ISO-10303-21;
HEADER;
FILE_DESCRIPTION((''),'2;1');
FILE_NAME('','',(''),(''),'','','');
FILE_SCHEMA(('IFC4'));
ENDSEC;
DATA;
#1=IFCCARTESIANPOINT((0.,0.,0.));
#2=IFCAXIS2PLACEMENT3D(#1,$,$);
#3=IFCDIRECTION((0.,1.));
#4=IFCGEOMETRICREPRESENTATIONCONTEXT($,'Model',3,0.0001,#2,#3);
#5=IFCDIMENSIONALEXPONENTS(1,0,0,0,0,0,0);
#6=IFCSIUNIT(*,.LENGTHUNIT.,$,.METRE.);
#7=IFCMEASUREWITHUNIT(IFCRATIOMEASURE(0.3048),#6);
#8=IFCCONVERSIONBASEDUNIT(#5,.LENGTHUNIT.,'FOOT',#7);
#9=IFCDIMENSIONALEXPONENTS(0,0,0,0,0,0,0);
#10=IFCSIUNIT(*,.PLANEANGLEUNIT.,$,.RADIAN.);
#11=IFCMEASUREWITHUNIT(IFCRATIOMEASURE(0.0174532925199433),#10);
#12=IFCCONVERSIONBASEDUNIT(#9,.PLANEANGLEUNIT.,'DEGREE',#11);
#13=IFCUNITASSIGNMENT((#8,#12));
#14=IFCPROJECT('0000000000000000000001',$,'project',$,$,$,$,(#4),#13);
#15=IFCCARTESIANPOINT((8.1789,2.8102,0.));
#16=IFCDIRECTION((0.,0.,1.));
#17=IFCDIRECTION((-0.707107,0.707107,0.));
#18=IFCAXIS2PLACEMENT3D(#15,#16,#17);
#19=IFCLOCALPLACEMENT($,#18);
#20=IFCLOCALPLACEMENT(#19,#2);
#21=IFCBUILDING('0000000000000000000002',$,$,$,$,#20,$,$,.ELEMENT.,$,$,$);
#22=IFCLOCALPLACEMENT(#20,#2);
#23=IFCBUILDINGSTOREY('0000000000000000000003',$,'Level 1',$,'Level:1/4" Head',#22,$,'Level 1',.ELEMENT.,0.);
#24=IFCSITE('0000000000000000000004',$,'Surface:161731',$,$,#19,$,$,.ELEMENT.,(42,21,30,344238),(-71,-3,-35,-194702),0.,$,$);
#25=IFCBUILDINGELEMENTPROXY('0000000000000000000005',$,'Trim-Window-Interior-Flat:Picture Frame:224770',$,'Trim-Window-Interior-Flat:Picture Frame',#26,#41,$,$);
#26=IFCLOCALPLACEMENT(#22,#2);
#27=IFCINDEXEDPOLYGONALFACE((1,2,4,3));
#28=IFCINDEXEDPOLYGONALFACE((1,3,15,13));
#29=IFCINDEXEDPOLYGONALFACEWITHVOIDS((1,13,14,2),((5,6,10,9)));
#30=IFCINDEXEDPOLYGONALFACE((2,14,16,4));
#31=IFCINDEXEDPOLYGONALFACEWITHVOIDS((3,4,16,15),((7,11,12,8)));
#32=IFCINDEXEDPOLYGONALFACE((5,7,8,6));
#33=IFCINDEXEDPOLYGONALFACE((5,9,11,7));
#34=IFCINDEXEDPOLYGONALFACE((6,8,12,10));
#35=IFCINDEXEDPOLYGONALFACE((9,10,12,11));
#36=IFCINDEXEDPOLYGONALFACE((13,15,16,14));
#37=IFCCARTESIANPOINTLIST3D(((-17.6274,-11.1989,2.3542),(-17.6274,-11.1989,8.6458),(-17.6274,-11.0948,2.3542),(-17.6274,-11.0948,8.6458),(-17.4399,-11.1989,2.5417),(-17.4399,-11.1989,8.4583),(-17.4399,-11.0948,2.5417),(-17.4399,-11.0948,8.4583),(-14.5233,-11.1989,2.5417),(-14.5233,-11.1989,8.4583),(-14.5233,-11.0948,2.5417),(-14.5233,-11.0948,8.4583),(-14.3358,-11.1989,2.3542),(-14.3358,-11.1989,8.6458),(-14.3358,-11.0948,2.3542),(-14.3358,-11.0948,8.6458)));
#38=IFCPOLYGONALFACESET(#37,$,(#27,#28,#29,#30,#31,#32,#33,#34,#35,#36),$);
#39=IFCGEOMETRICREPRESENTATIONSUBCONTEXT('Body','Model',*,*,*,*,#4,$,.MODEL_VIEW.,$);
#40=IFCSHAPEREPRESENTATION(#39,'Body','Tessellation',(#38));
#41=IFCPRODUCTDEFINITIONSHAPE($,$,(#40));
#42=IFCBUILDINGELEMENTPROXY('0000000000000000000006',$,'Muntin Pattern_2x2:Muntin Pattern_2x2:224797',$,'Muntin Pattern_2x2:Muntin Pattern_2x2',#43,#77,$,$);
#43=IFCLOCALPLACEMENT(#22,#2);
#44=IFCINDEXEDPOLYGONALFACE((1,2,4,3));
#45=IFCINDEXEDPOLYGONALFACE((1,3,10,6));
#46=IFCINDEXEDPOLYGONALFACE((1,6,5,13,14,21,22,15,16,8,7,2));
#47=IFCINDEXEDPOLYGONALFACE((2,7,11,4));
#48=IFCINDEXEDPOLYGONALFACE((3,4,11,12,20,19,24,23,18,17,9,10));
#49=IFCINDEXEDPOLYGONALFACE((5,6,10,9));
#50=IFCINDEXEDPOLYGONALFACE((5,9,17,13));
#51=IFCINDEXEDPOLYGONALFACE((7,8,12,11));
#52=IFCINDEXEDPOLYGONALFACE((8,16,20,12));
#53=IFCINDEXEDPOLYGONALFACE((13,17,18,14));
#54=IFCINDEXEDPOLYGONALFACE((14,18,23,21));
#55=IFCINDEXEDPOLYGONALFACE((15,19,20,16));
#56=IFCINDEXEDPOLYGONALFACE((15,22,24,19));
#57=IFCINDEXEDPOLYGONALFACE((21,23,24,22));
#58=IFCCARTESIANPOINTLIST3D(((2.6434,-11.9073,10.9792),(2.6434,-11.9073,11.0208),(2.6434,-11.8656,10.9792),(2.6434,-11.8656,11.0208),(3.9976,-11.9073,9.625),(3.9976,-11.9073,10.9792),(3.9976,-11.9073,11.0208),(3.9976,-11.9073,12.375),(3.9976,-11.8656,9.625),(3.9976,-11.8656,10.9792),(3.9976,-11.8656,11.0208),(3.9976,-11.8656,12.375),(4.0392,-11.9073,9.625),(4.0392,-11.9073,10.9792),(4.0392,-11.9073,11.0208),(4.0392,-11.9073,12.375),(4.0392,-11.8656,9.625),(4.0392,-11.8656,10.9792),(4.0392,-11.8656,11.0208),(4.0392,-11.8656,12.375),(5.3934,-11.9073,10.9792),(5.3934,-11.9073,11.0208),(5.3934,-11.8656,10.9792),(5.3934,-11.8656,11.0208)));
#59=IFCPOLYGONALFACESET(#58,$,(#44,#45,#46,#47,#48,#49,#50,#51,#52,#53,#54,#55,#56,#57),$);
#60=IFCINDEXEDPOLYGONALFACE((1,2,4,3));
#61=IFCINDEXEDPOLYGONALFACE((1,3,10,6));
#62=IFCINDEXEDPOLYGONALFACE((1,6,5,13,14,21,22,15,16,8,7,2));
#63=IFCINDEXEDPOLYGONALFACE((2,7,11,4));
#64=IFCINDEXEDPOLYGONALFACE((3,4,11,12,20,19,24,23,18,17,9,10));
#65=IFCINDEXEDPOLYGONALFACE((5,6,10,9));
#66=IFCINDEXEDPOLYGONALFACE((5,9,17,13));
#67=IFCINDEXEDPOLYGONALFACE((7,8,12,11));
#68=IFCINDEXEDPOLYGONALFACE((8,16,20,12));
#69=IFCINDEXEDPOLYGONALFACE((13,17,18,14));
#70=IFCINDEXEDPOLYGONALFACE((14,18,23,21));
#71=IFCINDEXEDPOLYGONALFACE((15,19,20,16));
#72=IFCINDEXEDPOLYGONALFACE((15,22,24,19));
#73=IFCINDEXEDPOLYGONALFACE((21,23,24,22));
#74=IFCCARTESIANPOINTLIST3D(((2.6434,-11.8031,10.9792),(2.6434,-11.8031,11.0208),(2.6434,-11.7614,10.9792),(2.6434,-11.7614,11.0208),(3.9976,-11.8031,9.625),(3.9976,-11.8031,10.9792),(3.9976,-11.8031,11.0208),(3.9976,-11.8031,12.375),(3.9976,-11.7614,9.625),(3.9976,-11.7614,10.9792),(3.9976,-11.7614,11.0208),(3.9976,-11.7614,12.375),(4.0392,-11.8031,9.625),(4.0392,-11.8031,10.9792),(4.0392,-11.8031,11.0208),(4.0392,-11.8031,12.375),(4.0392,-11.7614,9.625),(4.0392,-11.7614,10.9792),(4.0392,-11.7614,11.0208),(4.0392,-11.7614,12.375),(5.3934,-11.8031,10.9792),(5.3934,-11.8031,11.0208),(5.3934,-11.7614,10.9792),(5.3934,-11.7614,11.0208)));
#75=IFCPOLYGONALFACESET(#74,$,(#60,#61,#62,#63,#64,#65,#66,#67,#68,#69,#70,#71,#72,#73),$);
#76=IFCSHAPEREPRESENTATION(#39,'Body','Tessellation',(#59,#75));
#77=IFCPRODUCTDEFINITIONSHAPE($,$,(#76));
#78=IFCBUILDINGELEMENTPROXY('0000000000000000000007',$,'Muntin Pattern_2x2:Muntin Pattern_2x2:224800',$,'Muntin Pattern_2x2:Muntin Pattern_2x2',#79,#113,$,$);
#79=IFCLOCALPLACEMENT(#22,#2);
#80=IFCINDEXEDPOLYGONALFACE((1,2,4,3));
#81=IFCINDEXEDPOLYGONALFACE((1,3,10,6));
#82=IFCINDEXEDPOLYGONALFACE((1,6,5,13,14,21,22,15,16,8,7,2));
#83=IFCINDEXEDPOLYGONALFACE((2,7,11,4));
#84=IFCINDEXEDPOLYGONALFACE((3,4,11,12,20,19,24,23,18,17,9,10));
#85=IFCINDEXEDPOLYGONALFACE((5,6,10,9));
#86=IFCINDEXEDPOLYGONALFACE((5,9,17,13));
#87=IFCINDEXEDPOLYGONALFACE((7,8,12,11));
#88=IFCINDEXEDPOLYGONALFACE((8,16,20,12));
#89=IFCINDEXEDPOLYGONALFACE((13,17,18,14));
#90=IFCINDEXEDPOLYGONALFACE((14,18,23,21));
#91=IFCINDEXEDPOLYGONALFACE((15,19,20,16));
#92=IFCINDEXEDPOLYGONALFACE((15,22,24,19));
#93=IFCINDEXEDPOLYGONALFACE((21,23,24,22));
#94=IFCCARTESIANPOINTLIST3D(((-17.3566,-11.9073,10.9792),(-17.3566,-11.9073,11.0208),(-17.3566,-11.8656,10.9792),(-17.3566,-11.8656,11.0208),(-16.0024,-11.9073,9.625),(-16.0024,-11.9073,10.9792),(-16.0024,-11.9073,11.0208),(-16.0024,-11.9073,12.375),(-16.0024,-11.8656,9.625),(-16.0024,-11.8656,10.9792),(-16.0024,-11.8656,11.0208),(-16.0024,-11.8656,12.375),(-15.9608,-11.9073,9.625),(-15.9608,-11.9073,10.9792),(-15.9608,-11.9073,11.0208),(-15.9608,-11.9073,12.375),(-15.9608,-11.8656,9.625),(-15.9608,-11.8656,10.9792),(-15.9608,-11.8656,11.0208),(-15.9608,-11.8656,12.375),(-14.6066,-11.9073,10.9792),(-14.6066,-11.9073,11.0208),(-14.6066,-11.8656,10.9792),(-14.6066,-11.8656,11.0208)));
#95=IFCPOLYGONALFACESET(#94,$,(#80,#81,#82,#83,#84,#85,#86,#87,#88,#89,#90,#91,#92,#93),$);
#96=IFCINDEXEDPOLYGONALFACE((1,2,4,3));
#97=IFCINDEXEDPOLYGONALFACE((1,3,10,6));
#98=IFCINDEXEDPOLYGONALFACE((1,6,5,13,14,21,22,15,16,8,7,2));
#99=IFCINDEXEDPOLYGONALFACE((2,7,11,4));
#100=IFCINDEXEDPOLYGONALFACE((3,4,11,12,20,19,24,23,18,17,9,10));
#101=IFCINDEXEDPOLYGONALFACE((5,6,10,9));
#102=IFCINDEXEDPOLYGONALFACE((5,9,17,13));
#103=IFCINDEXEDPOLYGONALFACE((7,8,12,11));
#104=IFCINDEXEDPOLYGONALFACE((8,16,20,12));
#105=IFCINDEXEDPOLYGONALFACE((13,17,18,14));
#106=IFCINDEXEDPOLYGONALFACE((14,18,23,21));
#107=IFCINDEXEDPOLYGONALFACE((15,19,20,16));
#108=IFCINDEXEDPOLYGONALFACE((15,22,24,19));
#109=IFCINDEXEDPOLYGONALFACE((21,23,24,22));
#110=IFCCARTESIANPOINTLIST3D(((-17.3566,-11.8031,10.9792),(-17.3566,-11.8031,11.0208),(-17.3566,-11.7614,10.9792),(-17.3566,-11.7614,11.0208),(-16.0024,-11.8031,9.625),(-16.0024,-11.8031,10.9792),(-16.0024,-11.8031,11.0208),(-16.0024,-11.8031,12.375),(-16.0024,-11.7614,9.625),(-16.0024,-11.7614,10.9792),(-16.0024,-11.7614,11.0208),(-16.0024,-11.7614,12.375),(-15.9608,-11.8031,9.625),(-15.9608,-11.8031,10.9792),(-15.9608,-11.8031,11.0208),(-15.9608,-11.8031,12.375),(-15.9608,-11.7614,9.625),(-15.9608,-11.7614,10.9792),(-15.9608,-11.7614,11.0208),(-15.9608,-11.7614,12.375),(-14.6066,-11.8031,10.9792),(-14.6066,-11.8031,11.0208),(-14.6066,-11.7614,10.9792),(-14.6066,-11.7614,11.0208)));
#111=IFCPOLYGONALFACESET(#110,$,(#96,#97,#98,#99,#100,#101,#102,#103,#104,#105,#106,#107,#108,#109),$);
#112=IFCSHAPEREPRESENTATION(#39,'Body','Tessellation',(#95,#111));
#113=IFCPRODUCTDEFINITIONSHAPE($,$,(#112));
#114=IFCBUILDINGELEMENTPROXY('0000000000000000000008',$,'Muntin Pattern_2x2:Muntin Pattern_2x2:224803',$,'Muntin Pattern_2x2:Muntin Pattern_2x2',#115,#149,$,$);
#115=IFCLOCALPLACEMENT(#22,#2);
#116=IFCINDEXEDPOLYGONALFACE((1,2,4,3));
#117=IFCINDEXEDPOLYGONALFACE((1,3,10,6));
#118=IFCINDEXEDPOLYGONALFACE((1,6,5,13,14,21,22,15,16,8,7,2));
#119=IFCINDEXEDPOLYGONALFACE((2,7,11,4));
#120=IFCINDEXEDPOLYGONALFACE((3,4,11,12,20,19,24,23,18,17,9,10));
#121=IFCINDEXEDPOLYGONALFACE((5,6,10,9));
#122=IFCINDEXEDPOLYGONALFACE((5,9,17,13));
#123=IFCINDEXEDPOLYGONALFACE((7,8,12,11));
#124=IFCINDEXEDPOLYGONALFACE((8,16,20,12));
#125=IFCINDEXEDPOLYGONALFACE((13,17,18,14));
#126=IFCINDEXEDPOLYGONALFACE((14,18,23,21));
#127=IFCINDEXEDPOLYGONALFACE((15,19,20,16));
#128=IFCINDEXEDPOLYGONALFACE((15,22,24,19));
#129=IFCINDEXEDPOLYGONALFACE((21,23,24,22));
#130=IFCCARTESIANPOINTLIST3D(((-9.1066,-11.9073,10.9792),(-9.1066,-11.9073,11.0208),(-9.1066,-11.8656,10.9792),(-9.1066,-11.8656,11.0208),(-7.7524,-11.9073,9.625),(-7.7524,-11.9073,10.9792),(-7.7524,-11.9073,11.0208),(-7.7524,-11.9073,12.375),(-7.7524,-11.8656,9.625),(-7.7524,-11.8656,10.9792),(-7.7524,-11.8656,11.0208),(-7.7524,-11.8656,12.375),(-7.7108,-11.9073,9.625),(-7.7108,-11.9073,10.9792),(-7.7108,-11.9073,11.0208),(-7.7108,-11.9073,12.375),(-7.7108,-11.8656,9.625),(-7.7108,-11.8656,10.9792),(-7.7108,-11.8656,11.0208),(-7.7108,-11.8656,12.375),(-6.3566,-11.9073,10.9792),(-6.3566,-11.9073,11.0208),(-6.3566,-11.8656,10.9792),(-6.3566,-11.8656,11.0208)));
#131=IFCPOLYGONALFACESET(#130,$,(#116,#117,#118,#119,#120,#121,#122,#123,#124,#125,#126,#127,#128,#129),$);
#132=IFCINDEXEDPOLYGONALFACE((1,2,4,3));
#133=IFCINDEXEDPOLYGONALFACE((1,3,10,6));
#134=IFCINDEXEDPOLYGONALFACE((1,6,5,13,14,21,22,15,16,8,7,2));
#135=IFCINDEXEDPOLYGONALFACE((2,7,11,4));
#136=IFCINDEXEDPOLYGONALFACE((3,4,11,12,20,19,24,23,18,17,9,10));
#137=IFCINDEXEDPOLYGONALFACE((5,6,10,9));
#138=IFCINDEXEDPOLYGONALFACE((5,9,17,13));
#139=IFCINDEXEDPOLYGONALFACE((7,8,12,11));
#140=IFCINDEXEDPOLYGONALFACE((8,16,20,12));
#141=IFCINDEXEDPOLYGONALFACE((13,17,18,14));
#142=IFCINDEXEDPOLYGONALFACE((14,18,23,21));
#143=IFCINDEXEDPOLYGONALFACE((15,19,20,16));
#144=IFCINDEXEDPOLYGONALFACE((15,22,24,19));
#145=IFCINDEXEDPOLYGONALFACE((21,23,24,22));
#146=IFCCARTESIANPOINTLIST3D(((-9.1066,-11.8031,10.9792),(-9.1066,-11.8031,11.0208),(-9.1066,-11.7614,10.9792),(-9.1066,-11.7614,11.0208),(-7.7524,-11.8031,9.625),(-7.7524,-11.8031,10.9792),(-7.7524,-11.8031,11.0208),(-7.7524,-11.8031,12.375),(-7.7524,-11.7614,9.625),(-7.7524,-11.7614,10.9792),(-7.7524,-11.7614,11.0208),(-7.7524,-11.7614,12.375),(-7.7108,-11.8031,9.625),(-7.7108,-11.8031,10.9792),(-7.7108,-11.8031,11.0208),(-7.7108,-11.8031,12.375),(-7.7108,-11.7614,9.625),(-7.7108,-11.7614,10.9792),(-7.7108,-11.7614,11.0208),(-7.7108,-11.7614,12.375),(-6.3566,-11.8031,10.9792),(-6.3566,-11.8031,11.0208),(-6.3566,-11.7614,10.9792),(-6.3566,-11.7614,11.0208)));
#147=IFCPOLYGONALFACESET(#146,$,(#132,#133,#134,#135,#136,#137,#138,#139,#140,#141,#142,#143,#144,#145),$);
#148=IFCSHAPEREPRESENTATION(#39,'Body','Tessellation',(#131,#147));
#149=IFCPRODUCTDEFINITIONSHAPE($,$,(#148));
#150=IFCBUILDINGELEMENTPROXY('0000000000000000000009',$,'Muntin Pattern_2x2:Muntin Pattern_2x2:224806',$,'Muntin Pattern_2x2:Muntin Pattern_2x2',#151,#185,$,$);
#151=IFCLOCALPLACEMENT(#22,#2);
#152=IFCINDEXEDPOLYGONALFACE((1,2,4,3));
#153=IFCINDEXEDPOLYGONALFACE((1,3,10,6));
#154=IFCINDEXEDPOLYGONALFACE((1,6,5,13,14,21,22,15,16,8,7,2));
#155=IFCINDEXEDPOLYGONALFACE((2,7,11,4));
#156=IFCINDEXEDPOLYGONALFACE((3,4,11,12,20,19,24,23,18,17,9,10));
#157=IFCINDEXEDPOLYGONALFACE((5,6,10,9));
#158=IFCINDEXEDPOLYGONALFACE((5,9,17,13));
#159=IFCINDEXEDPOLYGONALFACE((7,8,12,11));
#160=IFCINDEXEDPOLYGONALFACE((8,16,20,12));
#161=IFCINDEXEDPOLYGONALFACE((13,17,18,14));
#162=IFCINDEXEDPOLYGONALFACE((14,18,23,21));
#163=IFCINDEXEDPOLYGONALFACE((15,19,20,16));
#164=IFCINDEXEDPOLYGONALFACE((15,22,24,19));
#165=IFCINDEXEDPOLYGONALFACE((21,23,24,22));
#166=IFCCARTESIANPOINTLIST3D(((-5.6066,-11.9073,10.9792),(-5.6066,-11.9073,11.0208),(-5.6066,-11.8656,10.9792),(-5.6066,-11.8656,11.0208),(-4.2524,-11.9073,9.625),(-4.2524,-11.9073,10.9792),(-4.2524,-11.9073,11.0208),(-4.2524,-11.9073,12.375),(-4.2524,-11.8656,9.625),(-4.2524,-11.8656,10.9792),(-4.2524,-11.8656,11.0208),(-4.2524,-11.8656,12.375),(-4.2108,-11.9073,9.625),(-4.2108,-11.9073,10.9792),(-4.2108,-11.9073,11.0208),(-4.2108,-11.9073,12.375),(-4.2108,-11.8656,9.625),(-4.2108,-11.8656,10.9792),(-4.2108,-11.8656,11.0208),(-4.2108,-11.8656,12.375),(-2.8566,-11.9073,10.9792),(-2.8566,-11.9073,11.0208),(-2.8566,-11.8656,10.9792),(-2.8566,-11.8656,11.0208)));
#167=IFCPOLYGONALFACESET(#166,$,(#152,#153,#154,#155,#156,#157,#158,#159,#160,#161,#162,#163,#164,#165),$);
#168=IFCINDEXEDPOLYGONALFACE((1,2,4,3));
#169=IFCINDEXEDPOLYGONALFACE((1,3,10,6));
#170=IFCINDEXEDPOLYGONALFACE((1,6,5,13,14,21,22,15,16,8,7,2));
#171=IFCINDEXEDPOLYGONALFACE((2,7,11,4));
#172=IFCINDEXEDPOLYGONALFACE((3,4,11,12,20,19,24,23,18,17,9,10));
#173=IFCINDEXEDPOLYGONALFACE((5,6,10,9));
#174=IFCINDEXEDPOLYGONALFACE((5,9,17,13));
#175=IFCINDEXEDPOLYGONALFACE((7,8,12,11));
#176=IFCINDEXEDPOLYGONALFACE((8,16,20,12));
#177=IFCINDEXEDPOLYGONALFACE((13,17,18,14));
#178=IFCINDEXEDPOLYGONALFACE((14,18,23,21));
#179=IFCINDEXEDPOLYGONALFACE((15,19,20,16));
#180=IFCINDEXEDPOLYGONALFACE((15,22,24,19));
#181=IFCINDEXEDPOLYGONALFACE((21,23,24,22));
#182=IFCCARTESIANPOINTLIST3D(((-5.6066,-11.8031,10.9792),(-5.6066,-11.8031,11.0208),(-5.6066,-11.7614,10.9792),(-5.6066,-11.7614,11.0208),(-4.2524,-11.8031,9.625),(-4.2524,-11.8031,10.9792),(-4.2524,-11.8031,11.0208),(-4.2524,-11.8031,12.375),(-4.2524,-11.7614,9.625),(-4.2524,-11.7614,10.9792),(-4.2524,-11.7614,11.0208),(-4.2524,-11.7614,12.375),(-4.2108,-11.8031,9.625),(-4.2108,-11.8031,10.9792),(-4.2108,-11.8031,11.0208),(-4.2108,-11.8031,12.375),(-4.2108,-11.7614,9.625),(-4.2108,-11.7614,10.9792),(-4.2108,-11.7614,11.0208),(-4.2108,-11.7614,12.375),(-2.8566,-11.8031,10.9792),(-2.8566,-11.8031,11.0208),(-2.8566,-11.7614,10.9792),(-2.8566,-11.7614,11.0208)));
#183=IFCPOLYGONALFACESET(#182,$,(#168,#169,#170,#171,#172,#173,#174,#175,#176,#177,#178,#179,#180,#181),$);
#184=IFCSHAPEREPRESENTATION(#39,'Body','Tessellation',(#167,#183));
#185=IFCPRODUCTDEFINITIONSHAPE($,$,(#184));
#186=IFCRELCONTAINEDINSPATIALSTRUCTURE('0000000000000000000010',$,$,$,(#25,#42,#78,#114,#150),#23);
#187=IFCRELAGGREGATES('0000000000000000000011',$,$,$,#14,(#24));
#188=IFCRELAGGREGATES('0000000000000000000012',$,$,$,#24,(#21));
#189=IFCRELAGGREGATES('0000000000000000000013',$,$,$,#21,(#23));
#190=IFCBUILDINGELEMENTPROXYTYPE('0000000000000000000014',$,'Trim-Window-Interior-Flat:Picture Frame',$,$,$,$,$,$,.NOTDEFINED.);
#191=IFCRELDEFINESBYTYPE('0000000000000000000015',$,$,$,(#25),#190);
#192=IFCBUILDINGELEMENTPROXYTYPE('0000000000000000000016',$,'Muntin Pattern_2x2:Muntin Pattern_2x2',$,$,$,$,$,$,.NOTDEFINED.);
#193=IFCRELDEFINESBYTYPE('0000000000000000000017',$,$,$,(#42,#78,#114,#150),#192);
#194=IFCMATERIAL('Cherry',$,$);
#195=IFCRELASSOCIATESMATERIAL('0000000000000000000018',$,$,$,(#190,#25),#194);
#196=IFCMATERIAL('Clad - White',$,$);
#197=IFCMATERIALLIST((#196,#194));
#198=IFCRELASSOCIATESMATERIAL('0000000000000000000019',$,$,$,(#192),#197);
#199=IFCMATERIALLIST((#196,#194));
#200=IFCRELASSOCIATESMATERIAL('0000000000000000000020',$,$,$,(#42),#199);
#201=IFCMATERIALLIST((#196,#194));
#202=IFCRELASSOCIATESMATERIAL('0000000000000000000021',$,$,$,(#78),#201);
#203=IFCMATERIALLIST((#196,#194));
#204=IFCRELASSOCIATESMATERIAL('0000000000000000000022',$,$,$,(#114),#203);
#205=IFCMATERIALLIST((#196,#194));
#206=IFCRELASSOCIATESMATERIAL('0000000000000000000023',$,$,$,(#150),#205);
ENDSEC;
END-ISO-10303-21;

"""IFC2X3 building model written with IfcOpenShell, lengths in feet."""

from ifc_helpers import new_model, entity, si_unit, converted_unit, direction, frame, origin, place, context, subcontext, project, spatial, polyline, outline, extrude, source, transform, mapped, material, material_list, type_object, type_shapes, element, save


model = new_model("IFC2X3")

# Units and contexts
model_context = context("Model", 3, precision=0.0001, world=origin(), true_north=direction((0.0, 1.0)))
body_context = subcontext(model_context, "Body", "Model", "MODEL_VIEW")
ifc_project = project(units=[converted_unit("LENGTHUNIT", "FOOT", entity("IfcRatioMeasure", 0.3048), si_unit("LENGTHUNIT", "METRE"), dimensions=[1, 0, 0, 0, 0, 0, 0]), converted_unit("PLANEANGLEUNIT", "DEGREE", entity("IfcRatioMeasure", 0.0174532925199433), si_unit("PLANEANGLEUNIT", "RADIAN"), dimensions=[0, 0, 0, 0, 0, 0, 0])], contexts=[model_context])

# Site, building, storey
site_placement = place(None, frame((8.1789, 2.8102, 0.0), z_axis=(0.0, 0.0, 1.0), x_axis=(-0.707107, 0.707107, 0.0)))
site = spatial("IfcSite", under=ifc_project, at=site_placement, Name="Surface:161731", CompositionType="ELEMENT", RefLatitude=(42, 21, 30, 344238), RefLongitude=(-71, -3, -35, -194702), RefElevation=0.0)
building_placement = place(site_placement, origin())
building = spatial("IfcBuilding", under=site, at=building_placement, CompositionType="ELEMENT")
storey_placement = place(building_placement, origin())
storey = spatial("IfcBuildingStorey", under=building, at=storey_placement, Name="Level 1", ObjectType="Level:1/4\" Head", LongName="Level 1", CompositionType="ELEMENT", Elevation=0.0)

# Building element proxies
ifc_material_1 = material(Name="Clad - White")
ifc_material_2 = material(Name="Cherry")
building_element_proxy_type_1 = type_object("IfcBuildingElementProxyType", Name="Trim-Window-Interior-Flat:Picture Frame", PredefinedType="NOTDEFINED", material=ifc_material_2)
shared_shape_1 = source(origin(), body_context, "Body", "SweptSolid", [
    extrude(outline(polyline([(-1.6458, -3.1458), (1.6458, -3.1458), (1.6458, 3.1458), (-1.6458, 3.1458), (-1.6458, -3.1458)]), holes=[polyline([(-1.4583, -2.9583), (-1.4583, 2.9583), (1.4583, 2.9583), (1.4583, -2.9583), (-1.4583, -2.9583)])]), frame((0.0, -3.0, 0.0), z_axis=(0.0, 0.0, 1.0), x_axis=(-1.0, 0.0, 0.0)), (0.0, 0.0, 1.0), 0.1042),
])
type_shapes(building_element_proxy_type_1, [shared_shape_1])
for number, where, z_axis, x_axis, name in (
    (1, (-15.9816, -11.1989, 8.5), (0.0, 1.0, 0.0), (-1.0, 0.0, 0.0), "Trim-Window-Interior-Flat:Picture Frame:224770"),
):
    element("IfcBuildingElementProxy", number, at=place(storey_placement, frame(where, z_axis=z_axis, x_axis=x_axis)), inside=storey, type_object=building_element_proxy_type_1, material=ifc_material_2, Name=name, ObjectType="Trim-Window-Interior-Flat:Picture Frame", context=body_context, shape_type="MappedRepresentation", body=[
        mapped(shared_shape_1, transform((0.0, 0.0, 0.0), scale=1.0)),
    ])
ifc_material_list_1 = material_list([ifc_material_1, ifc_material_2])
ifc_material_list_2 = material_list([ifc_material_1, ifc_material_2])
building_element_proxy_type_2 = type_object("IfcBuildingElementProxyType", Name="Muntin Pattern_2x2:Muntin Pattern_2x2", PredefinedType="NOTDEFINED", material=ifc_material_list_2)
shared_shape_2 = source(origin(), body_context, "Body", "SweptSolid", [
    extrude(outline(polyline([(0.0208, -0.0208), (1.375, -0.0208), (1.375, 0.0208), (0.0208, 0.0208), (0.0208, 1.375), (-0.0208, 1.375), (-0.0208, 0.0208), (-1.375, 0.0208), (-1.375, -0.0208), (-0.0208, -0.0208), (-0.0208, -1.375), (0.0208, -1.375), (0.0208, -0.0208)])), frame((0.0, -0.0729, 1.375), z_axis=(0.0, 1.0, 0.0), x_axis=(0.0, 0.0, 1.0)), (0.0, 0.0, 1.0), 0.0417),
    extrude(outline(polyline([(0.0208, -0.0208), (1.375, -0.0208), (1.375, 0.0208), (0.0208, 0.0208), (0.0208, 1.375), (-0.0208, 1.375), (-0.0208, 0.0208), (-1.375, 0.0208), (-1.375, -0.0208), (-0.0208, -0.0208), (-0.0208, -1.375), (0.0208, -1.375), (0.0208, -0.0208)])), frame((0.0, 0.0313, 1.375), z_axis=(0.0, 1.0, 0.0), x_axis=(0.0, 0.0, 1.0)), (0.0, 0.0, 1.0), 0.0417),
])
type_shapes(building_element_proxy_type_2, [shared_shape_2])
proxy_1_placement = place(storey_placement, frame((4.0184, -11.8344, 9.625)))
element("IfcBuildingElementProxy", 2, at=proxy_1_placement, inside=storey, type_object=building_element_proxy_type_2, material=ifc_material_list_1, Name="Muntin Pattern_2x2:Muntin Pattern_2x2:224797", ObjectType="Muntin Pattern_2x2:Muntin Pattern_2x2", context=body_context, shape_type="MappedRepresentation", body=[
    mapped(shared_shape_2, transform((0.0, 0.0, 0.0), scale=1.0)),
])
ifc_material_list_3 = material_list([ifc_material_1, ifc_material_2])
proxy_2_placement = place(storey_placement, frame((-15.9816, -11.8344, 9.625)))
element("IfcBuildingElementProxy", 3, at=proxy_2_placement, inside=storey, type_object=building_element_proxy_type_2, material=ifc_material_list_3, Name="Muntin Pattern_2x2:Muntin Pattern_2x2:224800", ObjectType="Muntin Pattern_2x2:Muntin Pattern_2x2", context=body_context, shape_type="MappedRepresentation", body=[
    mapped(shared_shape_2, transform((0.0, 0.0, 0.0), scale=1.0)),
])
ifc_material_list_4 = material_list([ifc_material_1, ifc_material_2])
proxy_3_placement = place(storey_placement, frame((-7.7316, -11.8344, 9.625)))
element("IfcBuildingElementProxy", 4, at=proxy_3_placement, inside=storey, type_object=building_element_proxy_type_2, material=ifc_material_list_4, Name="Muntin Pattern_2x2:Muntin Pattern_2x2:224803", ObjectType="Muntin Pattern_2x2:Muntin Pattern_2x2", context=body_context, shape_type="MappedRepresentation", body=[
    mapped(shared_shape_2, transform((0.0, 0.0, 0.0), scale=1.0)),
])
ifc_material_list_5 = material_list([ifc_material_1, ifc_material_2])
proxy_4_placement = place(storey_placement, frame((-4.2316, -11.8344, 9.625)))
element("IfcBuildingElementProxy", 5, at=proxy_4_placement, inside=storey, type_object=building_element_proxy_type_2, material=ifc_material_list_5, Name="Muntin Pattern_2x2:Muntin Pattern_2x2:224806", ObjectType="Muntin Pattern_2x2:Muntin Pattern_2x2", context=body_context, shape_type="MappedRepresentation", body=[
    mapped(shared_shape_2, transform((0.0, 0.0, 0.0), scale=1.0)),
])

save(model, "model.ifc")
